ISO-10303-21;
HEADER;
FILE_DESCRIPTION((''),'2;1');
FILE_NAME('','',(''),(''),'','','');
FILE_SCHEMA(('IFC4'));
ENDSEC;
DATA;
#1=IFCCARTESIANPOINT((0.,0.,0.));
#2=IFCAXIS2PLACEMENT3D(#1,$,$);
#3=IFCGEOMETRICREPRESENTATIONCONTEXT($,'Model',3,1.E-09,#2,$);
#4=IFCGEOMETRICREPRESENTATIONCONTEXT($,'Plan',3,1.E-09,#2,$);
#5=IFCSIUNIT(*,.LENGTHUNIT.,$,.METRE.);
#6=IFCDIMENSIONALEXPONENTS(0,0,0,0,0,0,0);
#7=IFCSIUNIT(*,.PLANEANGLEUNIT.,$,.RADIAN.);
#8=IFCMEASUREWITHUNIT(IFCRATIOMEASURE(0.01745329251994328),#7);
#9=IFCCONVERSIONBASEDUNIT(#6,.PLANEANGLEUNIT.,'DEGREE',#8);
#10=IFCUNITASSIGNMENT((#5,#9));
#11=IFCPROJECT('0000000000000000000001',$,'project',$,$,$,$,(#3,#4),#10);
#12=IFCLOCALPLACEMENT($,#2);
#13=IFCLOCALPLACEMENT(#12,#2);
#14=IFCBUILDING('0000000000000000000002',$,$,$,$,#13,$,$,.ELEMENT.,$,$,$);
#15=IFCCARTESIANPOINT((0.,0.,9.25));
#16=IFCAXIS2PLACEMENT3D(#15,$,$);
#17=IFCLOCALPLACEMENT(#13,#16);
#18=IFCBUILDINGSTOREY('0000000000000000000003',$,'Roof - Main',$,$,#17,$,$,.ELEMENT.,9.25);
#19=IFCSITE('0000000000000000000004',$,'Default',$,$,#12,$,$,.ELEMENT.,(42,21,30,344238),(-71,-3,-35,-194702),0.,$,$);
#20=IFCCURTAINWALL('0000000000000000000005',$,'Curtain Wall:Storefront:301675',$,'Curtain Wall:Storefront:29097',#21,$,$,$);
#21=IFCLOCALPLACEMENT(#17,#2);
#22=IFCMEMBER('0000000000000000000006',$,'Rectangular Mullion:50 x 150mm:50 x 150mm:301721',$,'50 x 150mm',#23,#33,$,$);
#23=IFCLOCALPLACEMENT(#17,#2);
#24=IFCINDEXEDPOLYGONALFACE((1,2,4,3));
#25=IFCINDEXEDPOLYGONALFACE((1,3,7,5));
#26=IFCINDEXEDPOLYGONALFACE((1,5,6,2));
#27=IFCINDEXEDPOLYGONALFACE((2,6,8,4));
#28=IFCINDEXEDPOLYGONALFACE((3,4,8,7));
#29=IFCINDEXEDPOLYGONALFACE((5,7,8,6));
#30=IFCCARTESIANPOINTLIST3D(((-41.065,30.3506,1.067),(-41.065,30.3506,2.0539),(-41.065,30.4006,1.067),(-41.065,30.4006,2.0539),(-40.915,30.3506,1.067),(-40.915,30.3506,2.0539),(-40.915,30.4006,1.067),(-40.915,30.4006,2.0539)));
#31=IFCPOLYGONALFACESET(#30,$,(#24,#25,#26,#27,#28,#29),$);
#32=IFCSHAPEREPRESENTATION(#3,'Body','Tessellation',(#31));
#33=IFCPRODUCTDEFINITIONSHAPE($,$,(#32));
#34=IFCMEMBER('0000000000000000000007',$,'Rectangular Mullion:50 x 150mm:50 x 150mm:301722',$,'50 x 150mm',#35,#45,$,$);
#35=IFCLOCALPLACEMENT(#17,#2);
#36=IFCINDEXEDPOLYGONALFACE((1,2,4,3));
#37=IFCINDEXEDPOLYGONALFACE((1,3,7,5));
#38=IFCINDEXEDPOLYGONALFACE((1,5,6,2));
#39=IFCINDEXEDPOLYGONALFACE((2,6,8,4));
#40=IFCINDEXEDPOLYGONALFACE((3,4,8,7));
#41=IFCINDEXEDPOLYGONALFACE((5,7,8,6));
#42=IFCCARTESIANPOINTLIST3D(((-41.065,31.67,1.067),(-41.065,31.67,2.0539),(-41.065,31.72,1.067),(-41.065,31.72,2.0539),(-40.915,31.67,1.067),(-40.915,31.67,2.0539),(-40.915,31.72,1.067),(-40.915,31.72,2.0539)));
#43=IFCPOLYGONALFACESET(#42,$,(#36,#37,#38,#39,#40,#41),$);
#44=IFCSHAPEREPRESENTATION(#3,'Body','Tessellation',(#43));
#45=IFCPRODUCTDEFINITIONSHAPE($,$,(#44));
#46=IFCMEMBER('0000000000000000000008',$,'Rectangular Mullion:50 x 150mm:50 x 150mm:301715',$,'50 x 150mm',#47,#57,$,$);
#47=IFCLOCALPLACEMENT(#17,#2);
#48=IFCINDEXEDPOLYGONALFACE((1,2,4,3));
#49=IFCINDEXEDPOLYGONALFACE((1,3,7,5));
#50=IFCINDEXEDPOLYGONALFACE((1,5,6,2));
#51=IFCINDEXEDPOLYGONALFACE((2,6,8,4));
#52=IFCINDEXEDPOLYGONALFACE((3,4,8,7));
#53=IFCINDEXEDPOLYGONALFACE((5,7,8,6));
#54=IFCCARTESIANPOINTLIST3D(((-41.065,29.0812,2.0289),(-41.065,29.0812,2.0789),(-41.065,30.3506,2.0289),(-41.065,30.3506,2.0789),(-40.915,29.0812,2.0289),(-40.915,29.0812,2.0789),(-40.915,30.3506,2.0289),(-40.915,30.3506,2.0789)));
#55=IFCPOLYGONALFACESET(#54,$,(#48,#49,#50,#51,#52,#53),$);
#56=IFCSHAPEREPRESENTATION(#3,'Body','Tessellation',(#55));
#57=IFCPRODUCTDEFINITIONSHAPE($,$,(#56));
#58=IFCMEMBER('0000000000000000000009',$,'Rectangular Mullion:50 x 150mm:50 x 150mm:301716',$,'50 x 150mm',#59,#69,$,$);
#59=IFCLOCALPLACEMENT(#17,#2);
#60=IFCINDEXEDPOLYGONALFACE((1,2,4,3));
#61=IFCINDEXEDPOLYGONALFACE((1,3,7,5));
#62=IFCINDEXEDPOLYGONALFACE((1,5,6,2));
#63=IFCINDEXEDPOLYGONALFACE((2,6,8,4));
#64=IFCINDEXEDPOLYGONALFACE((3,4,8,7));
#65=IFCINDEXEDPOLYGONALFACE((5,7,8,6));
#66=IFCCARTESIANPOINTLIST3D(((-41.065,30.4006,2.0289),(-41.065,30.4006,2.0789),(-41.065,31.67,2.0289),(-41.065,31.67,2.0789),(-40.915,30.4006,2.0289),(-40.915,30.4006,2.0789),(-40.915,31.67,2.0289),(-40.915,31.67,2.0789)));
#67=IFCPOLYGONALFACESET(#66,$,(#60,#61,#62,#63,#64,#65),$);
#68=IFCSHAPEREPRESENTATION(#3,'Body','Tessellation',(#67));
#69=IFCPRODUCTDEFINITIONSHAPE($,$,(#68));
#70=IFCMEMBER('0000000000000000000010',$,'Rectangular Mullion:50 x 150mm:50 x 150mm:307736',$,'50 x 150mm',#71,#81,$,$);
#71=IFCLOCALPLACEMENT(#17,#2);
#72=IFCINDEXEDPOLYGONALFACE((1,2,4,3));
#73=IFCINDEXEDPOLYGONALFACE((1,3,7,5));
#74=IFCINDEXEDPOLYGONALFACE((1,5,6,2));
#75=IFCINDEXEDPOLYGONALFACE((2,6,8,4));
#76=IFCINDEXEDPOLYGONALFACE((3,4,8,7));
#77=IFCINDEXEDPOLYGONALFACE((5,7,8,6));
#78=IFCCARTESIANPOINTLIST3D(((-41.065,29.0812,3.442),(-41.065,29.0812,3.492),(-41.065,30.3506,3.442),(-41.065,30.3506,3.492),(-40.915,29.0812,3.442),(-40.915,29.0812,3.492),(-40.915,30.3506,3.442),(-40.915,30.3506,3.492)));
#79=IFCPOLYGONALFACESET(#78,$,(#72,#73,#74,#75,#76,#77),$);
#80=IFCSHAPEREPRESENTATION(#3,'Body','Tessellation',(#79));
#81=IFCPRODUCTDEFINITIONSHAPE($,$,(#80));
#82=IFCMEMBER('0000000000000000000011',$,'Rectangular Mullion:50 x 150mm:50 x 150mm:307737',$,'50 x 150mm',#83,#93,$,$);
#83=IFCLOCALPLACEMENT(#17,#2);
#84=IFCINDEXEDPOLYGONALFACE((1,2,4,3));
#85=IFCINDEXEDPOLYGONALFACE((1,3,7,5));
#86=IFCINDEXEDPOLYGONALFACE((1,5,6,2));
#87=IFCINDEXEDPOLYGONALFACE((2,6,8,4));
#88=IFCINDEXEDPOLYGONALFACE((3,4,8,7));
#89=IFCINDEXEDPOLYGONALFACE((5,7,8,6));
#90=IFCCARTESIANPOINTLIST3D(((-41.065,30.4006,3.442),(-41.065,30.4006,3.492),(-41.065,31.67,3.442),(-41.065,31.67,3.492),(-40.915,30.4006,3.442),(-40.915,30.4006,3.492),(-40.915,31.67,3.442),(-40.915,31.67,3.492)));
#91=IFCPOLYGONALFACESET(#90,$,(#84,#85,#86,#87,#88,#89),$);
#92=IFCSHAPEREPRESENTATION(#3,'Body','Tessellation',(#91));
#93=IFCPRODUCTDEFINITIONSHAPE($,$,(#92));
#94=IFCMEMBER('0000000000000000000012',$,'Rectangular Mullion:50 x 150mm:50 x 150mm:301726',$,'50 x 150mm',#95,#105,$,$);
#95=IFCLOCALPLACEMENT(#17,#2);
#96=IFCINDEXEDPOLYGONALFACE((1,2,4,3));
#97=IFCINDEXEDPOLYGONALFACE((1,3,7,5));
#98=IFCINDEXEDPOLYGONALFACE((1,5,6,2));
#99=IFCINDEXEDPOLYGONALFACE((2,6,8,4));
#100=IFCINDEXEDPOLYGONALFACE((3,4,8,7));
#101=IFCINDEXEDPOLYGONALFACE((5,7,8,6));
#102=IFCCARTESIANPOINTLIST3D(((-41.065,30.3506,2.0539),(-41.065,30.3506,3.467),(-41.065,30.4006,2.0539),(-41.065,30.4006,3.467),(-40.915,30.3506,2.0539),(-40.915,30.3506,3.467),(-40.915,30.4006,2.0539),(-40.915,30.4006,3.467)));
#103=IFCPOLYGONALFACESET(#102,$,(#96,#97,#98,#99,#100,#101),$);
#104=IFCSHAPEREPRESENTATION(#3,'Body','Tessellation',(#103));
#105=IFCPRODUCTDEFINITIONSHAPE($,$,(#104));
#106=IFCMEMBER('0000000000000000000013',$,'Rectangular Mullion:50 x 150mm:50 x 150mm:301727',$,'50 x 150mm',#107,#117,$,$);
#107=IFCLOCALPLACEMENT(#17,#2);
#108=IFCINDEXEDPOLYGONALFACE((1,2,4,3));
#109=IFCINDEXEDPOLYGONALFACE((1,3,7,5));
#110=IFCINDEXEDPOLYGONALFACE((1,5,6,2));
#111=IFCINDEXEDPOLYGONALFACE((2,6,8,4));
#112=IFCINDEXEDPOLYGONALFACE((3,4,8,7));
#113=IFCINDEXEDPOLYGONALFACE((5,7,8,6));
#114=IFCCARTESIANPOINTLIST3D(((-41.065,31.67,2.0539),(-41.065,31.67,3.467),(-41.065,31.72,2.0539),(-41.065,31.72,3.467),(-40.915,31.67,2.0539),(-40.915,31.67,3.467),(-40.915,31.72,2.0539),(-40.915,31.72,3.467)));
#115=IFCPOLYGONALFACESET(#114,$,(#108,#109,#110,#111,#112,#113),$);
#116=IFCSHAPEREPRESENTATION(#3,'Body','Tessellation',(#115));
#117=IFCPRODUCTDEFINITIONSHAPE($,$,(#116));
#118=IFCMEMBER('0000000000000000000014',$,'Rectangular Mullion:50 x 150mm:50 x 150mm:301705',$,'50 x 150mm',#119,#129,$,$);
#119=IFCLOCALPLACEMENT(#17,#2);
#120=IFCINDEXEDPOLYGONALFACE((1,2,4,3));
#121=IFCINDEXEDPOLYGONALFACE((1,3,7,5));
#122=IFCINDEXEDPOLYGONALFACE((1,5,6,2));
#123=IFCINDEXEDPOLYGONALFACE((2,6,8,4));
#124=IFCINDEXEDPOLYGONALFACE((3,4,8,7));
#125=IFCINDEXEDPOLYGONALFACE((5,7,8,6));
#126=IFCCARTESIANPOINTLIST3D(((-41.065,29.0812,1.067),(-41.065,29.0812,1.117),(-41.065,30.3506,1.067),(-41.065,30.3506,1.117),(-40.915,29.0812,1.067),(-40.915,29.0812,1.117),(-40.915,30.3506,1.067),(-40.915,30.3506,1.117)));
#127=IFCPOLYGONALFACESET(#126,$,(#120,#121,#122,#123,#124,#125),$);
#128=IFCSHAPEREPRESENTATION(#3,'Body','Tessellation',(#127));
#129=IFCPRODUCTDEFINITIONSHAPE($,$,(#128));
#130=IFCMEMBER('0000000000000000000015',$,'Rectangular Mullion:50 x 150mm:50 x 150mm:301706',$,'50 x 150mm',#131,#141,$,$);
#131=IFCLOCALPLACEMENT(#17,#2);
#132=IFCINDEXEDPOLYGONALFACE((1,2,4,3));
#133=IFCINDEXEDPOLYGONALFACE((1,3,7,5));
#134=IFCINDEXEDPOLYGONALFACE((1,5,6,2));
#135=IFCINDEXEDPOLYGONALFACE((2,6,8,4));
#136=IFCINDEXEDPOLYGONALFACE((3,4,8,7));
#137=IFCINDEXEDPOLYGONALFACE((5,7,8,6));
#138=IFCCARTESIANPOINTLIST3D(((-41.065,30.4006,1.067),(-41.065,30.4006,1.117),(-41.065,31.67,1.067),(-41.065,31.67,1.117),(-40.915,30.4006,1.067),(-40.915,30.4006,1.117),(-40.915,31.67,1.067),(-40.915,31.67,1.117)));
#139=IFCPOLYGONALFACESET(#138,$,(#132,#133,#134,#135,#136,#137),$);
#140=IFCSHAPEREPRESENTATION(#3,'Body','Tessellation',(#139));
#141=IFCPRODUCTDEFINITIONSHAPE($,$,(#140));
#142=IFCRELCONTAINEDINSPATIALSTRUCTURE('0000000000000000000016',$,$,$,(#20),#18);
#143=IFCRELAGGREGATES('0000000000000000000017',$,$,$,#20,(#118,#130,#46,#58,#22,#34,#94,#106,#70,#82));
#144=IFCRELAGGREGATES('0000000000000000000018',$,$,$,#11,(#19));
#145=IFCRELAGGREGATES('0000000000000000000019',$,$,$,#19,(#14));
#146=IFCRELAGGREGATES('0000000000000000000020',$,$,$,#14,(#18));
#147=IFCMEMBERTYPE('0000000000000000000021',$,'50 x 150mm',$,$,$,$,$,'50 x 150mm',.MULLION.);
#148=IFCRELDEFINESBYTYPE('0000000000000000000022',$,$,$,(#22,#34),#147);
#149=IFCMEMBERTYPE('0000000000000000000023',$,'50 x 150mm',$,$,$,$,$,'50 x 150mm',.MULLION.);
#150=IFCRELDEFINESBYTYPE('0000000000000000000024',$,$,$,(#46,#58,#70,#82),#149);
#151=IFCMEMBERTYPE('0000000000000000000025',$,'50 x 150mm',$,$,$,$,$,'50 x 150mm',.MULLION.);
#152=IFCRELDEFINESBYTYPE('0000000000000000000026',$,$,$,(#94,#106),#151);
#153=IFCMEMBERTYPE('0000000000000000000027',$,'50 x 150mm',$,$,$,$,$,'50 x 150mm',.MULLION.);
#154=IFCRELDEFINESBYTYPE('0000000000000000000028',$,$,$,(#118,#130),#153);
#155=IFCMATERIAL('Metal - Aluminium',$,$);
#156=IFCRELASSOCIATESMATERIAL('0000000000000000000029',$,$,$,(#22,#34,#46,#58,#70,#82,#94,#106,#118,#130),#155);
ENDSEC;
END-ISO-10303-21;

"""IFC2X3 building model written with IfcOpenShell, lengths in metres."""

from ifc_helpers import new_model, entity, si_unit, converted_unit, frame, origin, origin_2d_with_axis, place, context, project, spatial, rectangle, extrude, source, transform, mapped, material, type_object, type_shapes, element, aggregate, save


model = new_model("IFC2X3")

# Units and contexts
model_context = context("Model", 3, precision=1e-09, world=origin())
plan_context = context("Plan", 3, precision=1e-09, world=origin())
ifc_project = project(units=[si_unit("LENGTHUNIT", "METRE"), converted_unit("PLANEANGLEUNIT", "DEGREE", entity("IfcRatioMeasure", 0.01745329251994328), si_unit("PLANEANGLEUNIT", "RADIAN"), dimensions=[0, 0, 0, 0, 0, 0, 0])], contexts=[model_context, plan_context])

# Site, building, storey
site_placement = place(None, origin())
site = spatial("IfcSite", under=ifc_project, at=site_placement, Name="Default", CompositionType="ELEMENT", RefLatitude=(42, 21, 30, 344238), RefLongitude=(-71, -3, -35, -194702), RefElevation=0.0)
building_placement = place(site_placement, origin())
building = spatial("IfcBuilding", under=site, at=building_placement, CompositionType="ELEMENT")
storey_placement = place(building_placement, frame((0.0, 0.0, 9.25)))
storey = spatial("IfcBuildingStorey", under=building, at=storey_placement, Name="Roof - Main", CompositionType="ELEMENT", Elevation=9.25)

# Curtain wall, members
curtain_wall_placement = place(storey_placement, origin())
curtain_wall = element("IfcCurtainWall", 1, at=curtain_wall_placement, inside=storey, Name="Curtain Wall:Storefront:301675", ObjectType="Curtain Wall:Storefront:29097")
ifc_material_1 = material(Name="Metal - Aluminium")
member_type_1 = type_object("IfcMemberType", Name="50 x 150mm", ElementType="50 x 150mm", PredefinedType="MULLION")
shared_shape_1 = source(origin(), model_context, "Body", "SweptSolid", [
    extrude(rectangle(XDim=0.05, YDim=0.15, at=origin_2d_with_axis()), frame((0.0, 0.0, -0.9869), z_axis=(0.0, 0.0, 1.0), x_axis=(-1.0, 0.0, 0.0)), (0.0, 0.0, 1.0), 0.9869),
])
type_shapes(member_type_1, [shared_shape_1])
member_1_placement = place(storey_placement, frame((-40.99, 30.3756, 1.067), z_axis=(0.0, 0.0, -1.0), x_axis=(0.0, 1.0, 0.0)))
member_1 = element("IfcMember", 2, at=member_1_placement, type_object=member_type_1, material=ifc_material_1, Name="Rectangular Mullion:50 x 150mm:50 x 150mm:301721", ObjectType="50 x 150mm", context=model_context, shape_type="MappedRepresentation", body=[
    mapped(shared_shape_1, transform((0.0, 0.0, 0.0), scale=1.0)),
])
member_2_placement = place(storey_placement, frame((-40.99, 31.695, 1.067), z_axis=(0.0, 0.0, -1.0), x_axis=(0.0, 1.0, 0.0)))
member_2 = element("IfcMember", 3, at=member_2_placement, type_object=member_type_1, material=ifc_material_1, Name="Rectangular Mullion:50 x 150mm:50 x 150mm:301722", ObjectType="50 x 150mm", context=model_context, shape_type="MappedRepresentation", body=[
    mapped(shared_shape_1, transform((0.0, 0.0, 0.0), scale=1.0)),
])
member_type_2 = type_object("IfcMemberType", Name="50 x 150mm", ElementType="50 x 150mm", PredefinedType="MULLION")
shared_shape_2 = source(origin(), model_context, "Body", "SweptSolid", [
    extrude(rectangle(XDim=0.05, YDim=0.15, at=origin_2d_with_axis()), frame((0.0, 0.0, -1.2694), z_axis=(0.0, 0.0, 1.0), x_axis=(-1.0, 0.0, 0.0)), (0.0, 0.0, 1.0), 1.2694),
])
type_shapes(member_type_2, [shared_shape_2])
member_3_placement = place(storey_placement, frame((-40.99, 30.3506, 2.0539), z_axis=(0.0, 1.0, 0.0), x_axis=(0.0, 0.0, 1.0)))
member_3 = element("IfcMember", 4, at=member_3_placement, type_object=member_type_2, material=ifc_material_1, Name="Rectangular Mullion:50 x 150mm:50 x 150mm:301715", ObjectType="50 x 150mm", context=model_context, shape_type="MappedRepresentation", body=[
    mapped(shared_shape_2, transform((0.0, 0.0, 0.0), scale=1.0)),
])
member_4_placement = place(storey_placement, frame((-40.99, 31.67, 2.0539), z_axis=(0.0, 1.0, 0.0), x_axis=(0.0, 0.0, 1.0)))
member_4 = element("IfcMember", 5, at=member_4_placement, type_object=member_type_2, material=ifc_material_1, Name="Rectangular Mullion:50 x 150mm:50 x 150mm:301716", ObjectType="50 x 150mm", context=model_context, shape_type="MappedRepresentation", body=[
    mapped(shared_shape_2, transform((0.0, 0.0, 0.0), scale=1.0)),
])
member_5_placement = place(storey_placement, frame((-40.99, 30.3506, 3.467), z_axis=(0.0, 1.0, 0.0), x_axis=(0.0, 0.0, 1.0)))
member_5 = element("IfcMember", 6, at=member_5_placement, type_object=member_type_2, material=ifc_material_1, Name="Rectangular Mullion:50 x 150mm:50 x 150mm:307736", ObjectType="50 x 150mm", context=model_context, shape_type="MappedRepresentation", body=[
    mapped(shared_shape_2, transform((0.0, 0.0, 0.0), scale=1.0)),
])
member_6_placement = place(storey_placement, frame((-40.99, 31.67, 3.467), z_axis=(0.0, 1.0, 0.0), x_axis=(0.0, 0.0, 1.0)))
member_6 = element("IfcMember", 7, at=member_6_placement, type_object=member_type_2, material=ifc_material_1, Name="Rectangular Mullion:50 x 150mm:50 x 150mm:307737", ObjectType="50 x 150mm", context=model_context, shape_type="MappedRepresentation", body=[
    mapped(shared_shape_2, transform((0.0, 0.0, 0.0), scale=1.0)),
])
member_type_3 = type_object("IfcMemberType", Name="50 x 150mm", ElementType="50 x 150mm", PredefinedType="MULLION")
shared_shape_3 = source(origin(), model_context, "Body", "SweptSolid", [
    extrude(rectangle(XDim=0.05, YDim=0.15, at=origin_2d_with_axis()), frame((0.0, 0.0, -1.4131), z_axis=(0.0, 0.0, 1.0), x_axis=(-1.0, 0.0, 0.0)), (0.0, 0.0, 1.0), 1.4131),
])
type_shapes(member_type_3, [shared_shape_3])
member_7_placement = place(storey_placement, frame((-40.99, 30.3756, 2.0539), z_axis=(0.0, 0.0, -1.0), x_axis=(0.0, 1.0, 0.0)))
member_7 = element("IfcMember", 8, at=member_7_placement, type_object=member_type_3, material=ifc_material_1, Name="Rectangular Mullion:50 x 150mm:50 x 150mm:301726", ObjectType="50 x 150mm", context=model_context, shape_type="MappedRepresentation", body=[
    mapped(shared_shape_3, transform((0.0, 0.0, 0.0), scale=1.0)),
])
member_8_placement = place(storey_placement, frame((-40.99, 31.695, 2.0539), z_axis=(0.0, 0.0, -1.0), x_axis=(0.0, 1.0, 0.0)))
member_8 = element("IfcMember", 9, at=member_8_placement, type_object=member_type_3, material=ifc_material_1, Name="Rectangular Mullion:50 x 150mm:50 x 150mm:301727", ObjectType="50 x 150mm", context=model_context, shape_type="MappedRepresentation", body=[
    mapped(shared_shape_3, transform((0.0, 0.0, 0.0), scale=1.0)),
])
member_type_4 = type_object("IfcMemberType", Name="50 x 150mm", ElementType="50 x 150mm", PredefinedType="MULLION")
shared_shape_4 = source(origin(), model_context, "Body", "SweptSolid", [
    extrude(rectangle(XDim=0.05, YDim=0.15, at=origin_2d_with_axis()), frame((-0.025, 0.0, -1.2694), z_axis=(0.0, 0.0, 1.0), x_axis=(-1.0, 0.0, 0.0)), (0.0, 0.0, 1.0), 1.2694),
])
type_shapes(member_type_4, [shared_shape_4])
member_9_placement = place(storey_placement, frame((-40.99, 29.0812, 1.067), z_axis=(0.0, -1.0, 0.0), x_axis=(0.0, 0.0, -1.0)))
member_9 = element("IfcMember", 10, at=member_9_placement, type_object=member_type_4, material=ifc_material_1, Name="Rectangular Mullion:50 x 150mm:50 x 150mm:301705", ObjectType="50 x 150mm", context=model_context, shape_type="MappedRepresentation", body=[
    mapped(shared_shape_4, transform((0.0, 0.0, 0.0), scale=1.0)),
])
member_10_placement = place(storey_placement, frame((-40.99, 30.4006, 1.067), z_axis=(0.0, -1.0, 0.0), x_axis=(0.0, 0.0, -1.0)))
member_10 = element("IfcMember", 11, at=member_10_placement, type_object=member_type_4, material=ifc_material_1, Name="Rectangular Mullion:50 x 150mm:50 x 150mm:301706", ObjectType="50 x 150mm", context=model_context, shape_type="MappedRepresentation", body=[
    mapped(shared_shape_4, transform((0.0, 0.0, 0.0), scale=1.0)),
])
aggregate(curtain_wall, [member_9, member_10, member_3, member_4, member_1, member_2, member_7, member_8, member_5, member_6])

save(model, "model.ifc")
